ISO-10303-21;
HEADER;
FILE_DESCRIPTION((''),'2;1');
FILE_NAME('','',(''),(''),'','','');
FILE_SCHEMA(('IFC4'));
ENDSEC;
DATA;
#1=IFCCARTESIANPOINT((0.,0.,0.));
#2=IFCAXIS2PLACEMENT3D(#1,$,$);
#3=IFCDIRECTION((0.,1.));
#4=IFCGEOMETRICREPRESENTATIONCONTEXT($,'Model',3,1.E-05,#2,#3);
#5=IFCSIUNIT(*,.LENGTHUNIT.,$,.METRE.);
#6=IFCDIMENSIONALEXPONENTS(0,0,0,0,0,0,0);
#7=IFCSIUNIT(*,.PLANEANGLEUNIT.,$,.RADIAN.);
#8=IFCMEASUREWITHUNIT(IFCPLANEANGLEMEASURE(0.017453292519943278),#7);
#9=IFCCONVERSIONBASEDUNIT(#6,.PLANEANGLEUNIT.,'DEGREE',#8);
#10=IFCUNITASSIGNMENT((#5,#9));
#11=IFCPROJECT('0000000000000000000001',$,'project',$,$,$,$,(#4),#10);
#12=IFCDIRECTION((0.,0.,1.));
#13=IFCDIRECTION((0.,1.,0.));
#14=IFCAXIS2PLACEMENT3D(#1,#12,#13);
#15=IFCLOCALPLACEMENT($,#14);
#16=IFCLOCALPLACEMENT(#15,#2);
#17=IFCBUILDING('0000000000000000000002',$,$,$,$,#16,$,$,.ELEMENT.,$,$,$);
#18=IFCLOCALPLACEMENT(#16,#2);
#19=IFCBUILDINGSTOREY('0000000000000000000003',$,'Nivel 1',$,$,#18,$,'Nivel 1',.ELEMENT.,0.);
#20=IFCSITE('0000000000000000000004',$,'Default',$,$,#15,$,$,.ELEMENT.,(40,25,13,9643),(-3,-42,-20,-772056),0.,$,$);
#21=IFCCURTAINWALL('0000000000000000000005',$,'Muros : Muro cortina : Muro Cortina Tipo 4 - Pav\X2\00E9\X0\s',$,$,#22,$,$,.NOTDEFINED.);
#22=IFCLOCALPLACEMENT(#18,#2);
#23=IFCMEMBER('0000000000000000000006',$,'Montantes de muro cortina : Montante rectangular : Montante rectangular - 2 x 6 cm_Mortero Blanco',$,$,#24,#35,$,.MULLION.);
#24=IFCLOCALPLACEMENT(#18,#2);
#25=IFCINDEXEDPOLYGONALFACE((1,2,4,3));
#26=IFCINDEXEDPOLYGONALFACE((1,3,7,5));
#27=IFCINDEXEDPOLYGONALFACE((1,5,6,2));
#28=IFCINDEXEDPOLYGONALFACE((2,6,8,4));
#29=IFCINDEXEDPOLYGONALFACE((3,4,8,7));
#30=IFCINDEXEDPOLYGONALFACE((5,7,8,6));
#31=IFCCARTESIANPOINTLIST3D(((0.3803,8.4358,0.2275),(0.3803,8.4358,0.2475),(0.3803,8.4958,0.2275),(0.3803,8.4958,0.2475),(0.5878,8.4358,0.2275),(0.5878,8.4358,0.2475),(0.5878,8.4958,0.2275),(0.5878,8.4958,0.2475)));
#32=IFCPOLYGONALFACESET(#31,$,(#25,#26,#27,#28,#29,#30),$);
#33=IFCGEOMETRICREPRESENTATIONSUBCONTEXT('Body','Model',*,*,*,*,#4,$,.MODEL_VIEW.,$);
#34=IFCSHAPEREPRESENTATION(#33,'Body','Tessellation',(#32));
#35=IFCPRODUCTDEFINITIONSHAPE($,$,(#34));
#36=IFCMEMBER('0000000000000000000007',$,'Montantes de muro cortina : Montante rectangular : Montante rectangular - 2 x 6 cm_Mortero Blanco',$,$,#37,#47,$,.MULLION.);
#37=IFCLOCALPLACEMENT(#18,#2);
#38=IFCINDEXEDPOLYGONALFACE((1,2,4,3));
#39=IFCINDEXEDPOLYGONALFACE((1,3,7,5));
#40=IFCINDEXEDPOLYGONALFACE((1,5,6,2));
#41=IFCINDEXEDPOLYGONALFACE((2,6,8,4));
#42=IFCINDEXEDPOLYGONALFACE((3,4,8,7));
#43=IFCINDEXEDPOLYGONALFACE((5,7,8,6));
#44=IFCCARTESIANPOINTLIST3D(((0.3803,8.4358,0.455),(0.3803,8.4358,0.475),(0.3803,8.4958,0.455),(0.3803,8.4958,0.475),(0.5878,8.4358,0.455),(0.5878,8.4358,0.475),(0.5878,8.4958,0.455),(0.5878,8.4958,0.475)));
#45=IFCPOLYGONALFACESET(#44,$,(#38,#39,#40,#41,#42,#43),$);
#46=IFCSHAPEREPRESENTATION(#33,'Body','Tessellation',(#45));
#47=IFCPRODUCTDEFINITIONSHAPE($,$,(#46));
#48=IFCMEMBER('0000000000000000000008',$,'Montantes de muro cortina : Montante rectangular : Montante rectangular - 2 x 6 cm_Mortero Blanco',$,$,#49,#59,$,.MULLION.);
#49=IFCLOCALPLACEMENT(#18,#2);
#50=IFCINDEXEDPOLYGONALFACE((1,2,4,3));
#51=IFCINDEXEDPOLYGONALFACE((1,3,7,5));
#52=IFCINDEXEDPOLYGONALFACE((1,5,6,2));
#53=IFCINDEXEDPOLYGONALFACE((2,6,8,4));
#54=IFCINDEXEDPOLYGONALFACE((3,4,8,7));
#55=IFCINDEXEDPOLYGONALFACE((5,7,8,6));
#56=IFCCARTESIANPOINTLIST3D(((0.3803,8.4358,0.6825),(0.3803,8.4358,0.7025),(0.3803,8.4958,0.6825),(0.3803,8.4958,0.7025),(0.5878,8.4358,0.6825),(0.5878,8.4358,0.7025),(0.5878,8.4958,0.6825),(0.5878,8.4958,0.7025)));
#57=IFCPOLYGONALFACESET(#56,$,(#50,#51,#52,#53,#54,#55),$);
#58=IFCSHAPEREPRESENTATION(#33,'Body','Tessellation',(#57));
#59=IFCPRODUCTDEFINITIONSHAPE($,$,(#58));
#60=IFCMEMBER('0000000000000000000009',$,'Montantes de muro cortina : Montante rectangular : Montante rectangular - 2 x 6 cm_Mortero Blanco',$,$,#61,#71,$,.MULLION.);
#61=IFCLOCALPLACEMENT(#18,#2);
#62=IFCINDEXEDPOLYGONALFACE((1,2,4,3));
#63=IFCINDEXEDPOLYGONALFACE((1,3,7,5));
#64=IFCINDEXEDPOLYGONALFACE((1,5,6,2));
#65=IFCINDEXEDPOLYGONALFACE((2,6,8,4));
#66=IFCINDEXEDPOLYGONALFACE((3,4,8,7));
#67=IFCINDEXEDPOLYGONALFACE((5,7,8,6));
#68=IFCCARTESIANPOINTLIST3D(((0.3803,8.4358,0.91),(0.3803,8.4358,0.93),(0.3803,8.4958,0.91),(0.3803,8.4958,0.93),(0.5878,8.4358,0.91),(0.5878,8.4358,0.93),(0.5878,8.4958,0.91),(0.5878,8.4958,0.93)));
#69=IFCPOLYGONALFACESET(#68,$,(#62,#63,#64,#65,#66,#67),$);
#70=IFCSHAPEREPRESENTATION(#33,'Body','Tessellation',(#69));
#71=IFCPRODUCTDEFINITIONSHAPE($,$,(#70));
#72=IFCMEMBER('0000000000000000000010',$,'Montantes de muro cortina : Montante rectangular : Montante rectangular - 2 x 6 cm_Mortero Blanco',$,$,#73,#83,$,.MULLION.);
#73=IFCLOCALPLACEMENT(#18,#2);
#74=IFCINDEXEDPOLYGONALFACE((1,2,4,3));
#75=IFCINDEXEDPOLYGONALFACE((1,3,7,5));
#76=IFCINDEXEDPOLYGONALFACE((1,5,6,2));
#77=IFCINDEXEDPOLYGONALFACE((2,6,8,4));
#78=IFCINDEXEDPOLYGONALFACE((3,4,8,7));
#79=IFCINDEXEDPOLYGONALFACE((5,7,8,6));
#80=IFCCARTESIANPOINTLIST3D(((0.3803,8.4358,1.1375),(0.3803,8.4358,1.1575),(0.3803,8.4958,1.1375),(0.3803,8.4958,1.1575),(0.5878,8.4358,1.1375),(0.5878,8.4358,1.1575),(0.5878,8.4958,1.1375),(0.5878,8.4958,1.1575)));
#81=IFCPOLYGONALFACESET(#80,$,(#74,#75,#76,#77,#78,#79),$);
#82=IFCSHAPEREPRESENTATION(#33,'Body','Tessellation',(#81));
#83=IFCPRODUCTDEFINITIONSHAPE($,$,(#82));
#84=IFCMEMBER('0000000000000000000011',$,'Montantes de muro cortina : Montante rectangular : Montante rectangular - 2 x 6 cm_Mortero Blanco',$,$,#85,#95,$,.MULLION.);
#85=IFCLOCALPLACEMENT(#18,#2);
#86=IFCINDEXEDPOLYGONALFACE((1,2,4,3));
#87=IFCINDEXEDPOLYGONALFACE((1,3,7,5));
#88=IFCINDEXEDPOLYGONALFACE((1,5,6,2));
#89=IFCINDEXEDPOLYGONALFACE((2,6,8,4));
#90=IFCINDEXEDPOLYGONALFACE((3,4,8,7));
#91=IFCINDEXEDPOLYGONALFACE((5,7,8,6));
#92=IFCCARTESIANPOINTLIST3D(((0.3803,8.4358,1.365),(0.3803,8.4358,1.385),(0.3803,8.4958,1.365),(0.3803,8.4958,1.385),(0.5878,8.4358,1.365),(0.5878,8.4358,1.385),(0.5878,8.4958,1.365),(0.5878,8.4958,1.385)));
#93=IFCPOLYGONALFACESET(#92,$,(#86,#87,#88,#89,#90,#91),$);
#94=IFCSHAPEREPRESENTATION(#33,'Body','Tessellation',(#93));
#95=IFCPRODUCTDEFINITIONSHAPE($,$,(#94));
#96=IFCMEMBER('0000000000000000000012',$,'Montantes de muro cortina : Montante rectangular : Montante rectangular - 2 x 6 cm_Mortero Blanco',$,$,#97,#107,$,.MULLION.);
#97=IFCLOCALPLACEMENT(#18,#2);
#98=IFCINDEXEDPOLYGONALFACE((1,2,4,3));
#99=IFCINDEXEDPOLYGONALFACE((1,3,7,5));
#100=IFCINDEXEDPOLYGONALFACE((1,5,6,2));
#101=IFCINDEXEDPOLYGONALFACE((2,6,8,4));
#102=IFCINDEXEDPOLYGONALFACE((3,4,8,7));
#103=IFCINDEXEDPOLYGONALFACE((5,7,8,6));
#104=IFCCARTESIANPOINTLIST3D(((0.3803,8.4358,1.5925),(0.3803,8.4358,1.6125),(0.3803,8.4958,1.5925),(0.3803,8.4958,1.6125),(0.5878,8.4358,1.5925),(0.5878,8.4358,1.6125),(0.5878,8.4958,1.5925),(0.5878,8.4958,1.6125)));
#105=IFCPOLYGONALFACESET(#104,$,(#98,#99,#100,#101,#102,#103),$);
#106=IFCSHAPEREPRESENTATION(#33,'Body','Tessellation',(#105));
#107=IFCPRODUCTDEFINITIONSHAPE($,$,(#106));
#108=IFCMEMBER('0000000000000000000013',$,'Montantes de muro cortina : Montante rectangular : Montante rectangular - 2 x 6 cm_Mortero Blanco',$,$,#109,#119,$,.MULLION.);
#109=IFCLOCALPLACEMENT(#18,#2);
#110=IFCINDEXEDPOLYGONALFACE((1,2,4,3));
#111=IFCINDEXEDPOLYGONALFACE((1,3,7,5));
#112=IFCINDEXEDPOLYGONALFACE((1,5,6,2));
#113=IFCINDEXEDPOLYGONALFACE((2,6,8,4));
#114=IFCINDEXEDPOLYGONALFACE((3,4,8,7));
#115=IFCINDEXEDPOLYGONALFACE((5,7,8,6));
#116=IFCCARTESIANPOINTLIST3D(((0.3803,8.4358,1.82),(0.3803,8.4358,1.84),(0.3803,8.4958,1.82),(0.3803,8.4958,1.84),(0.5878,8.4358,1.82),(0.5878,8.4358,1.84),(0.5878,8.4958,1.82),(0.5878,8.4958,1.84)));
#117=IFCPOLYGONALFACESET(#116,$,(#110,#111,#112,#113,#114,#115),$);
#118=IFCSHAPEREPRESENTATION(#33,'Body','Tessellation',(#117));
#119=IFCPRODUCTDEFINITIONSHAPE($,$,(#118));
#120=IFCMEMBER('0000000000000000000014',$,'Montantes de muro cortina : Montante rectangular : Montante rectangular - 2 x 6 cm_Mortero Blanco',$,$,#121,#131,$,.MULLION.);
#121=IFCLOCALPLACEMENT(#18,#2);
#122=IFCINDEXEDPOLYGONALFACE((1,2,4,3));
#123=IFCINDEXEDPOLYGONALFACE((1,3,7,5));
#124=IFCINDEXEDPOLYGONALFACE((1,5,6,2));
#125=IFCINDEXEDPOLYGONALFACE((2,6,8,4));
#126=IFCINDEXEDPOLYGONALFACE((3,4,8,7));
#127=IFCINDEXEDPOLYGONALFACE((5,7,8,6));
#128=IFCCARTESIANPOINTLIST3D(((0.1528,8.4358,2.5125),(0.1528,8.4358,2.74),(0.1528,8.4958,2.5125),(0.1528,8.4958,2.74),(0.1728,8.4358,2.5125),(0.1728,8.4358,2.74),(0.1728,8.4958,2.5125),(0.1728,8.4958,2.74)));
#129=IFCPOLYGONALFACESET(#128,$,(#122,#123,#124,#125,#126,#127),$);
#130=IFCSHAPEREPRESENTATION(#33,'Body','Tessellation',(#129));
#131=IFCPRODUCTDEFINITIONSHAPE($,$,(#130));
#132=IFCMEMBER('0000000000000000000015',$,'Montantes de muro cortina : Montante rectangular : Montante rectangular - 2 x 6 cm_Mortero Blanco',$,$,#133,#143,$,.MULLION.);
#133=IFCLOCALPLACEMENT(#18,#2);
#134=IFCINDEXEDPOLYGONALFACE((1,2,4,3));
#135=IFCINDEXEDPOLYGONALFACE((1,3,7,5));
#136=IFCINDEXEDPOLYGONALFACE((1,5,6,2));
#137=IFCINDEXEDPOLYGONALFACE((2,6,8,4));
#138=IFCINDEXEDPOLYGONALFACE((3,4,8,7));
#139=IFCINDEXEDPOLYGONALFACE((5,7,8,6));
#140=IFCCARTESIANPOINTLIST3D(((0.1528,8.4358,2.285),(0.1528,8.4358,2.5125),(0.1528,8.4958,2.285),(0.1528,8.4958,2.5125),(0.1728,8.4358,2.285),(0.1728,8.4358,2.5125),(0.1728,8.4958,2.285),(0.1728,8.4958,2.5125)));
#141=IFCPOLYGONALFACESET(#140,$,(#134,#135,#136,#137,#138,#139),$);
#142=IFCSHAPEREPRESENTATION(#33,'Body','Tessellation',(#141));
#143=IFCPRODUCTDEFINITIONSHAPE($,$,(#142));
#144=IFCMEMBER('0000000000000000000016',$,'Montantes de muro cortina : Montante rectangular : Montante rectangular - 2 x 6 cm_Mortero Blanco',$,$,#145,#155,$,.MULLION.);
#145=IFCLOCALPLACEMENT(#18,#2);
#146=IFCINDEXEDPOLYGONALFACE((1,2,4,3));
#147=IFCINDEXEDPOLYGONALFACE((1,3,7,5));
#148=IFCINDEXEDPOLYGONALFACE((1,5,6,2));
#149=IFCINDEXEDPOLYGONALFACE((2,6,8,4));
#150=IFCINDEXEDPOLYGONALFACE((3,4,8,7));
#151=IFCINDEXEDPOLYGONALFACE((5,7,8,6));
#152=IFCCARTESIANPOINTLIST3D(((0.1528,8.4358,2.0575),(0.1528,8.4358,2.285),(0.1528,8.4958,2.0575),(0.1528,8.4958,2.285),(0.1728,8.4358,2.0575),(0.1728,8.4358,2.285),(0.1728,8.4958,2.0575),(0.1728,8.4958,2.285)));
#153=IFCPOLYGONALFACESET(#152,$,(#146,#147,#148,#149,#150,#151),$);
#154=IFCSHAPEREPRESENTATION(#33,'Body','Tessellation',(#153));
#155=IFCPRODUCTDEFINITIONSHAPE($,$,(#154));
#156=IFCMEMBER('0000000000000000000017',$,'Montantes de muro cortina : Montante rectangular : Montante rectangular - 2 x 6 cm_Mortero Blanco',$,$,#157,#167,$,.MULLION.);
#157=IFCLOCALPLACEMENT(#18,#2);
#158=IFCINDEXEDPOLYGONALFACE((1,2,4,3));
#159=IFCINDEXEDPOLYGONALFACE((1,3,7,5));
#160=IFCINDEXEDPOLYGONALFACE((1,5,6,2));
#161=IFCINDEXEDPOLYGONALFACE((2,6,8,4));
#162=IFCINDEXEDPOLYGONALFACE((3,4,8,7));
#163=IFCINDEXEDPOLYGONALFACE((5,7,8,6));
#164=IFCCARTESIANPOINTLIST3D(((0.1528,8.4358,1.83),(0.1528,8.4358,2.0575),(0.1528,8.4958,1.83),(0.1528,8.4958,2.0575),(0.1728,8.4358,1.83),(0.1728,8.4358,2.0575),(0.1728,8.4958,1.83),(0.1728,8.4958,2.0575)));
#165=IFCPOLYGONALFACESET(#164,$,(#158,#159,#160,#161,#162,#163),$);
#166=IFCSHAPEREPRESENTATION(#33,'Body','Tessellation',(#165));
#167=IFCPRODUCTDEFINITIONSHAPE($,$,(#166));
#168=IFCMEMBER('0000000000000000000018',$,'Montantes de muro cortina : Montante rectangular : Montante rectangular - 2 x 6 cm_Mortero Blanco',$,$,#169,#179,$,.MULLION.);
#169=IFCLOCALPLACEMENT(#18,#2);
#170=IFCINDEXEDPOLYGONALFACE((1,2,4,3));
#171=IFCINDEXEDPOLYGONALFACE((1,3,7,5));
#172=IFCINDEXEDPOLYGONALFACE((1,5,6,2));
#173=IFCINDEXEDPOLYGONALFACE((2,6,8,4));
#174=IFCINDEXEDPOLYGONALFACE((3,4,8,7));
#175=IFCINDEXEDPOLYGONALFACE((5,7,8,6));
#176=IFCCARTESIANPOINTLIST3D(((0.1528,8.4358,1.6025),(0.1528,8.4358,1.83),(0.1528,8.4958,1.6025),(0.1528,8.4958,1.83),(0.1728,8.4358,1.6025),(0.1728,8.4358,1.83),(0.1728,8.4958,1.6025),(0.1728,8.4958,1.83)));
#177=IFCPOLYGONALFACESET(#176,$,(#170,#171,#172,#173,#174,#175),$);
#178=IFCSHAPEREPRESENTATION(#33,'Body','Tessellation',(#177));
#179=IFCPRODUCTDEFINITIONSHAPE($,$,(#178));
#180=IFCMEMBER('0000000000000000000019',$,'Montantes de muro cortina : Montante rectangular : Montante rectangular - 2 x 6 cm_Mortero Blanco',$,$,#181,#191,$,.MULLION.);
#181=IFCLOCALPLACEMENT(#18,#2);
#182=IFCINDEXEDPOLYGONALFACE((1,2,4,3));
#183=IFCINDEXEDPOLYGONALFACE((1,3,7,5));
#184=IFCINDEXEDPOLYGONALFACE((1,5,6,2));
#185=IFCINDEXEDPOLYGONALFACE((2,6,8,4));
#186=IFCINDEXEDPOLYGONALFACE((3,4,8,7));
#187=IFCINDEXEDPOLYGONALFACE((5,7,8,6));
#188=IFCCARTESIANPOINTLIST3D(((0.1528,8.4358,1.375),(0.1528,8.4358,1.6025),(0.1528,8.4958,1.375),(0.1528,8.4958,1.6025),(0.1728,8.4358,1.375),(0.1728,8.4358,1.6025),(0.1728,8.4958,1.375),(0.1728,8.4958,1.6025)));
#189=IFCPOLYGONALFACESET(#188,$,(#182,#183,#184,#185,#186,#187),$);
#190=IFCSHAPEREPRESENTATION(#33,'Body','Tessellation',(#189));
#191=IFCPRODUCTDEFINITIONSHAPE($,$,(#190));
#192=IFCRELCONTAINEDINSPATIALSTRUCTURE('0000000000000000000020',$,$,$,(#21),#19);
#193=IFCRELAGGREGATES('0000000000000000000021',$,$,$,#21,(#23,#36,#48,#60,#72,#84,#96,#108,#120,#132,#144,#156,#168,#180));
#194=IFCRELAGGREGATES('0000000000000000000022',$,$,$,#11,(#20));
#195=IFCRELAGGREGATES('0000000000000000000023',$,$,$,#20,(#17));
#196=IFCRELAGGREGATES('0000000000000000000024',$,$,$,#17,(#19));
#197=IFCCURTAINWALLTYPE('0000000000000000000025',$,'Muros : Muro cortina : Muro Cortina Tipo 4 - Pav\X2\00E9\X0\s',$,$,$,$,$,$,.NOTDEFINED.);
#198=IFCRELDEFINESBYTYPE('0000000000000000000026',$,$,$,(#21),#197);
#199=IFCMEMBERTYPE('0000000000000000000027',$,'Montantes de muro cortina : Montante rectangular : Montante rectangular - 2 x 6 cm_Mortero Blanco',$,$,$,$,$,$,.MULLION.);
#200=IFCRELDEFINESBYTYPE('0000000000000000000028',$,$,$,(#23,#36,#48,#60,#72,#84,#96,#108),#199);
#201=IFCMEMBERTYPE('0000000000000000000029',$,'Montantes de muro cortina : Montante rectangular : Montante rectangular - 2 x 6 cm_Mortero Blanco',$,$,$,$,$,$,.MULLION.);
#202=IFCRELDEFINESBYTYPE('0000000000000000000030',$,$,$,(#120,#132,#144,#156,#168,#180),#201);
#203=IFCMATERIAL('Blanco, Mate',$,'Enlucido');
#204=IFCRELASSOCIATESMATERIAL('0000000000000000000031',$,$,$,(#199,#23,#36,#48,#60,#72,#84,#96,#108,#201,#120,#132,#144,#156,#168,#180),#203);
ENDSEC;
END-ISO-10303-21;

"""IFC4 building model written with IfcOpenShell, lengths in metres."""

from ifc_helpers import new_model, entity, si_unit, converted_unit, direction, frame, origin, place, context, subcontext, project, spatial, indexed_curve, outline, extrude, source, transform, mapped, material, type_object, type_shapes, element, aggregate, save


model = new_model("IFC4")

# Units and contexts
model_context = context("Model", 3, precision=1e-05, world=origin(), true_north=direction((0.0, 1.0)))
body_context = subcontext(model_context, "Body", "Model", "MODEL_VIEW")
ifc_project = project(units=[si_unit("LENGTHUNIT", "METRE"), converted_unit("PLANEANGLEUNIT", "DEGREE", entity("IfcPlaneAngleMeasure", 0.017453292519943278), si_unit("PLANEANGLEUNIT", "RADIAN"), dimensions=[0, 0, 0, 0, 0, 0, 0])], contexts=[model_context])

# Site, building, storey
site_placement = place(None, frame((0.0, 0.0, 0.0), z_axis=(0.0, 0.0, 1.0), x_axis=(0.0, 1.0, 0.0)))
site = spatial("IfcSite", under=ifc_project, at=site_placement, Name="Default", CompositionType="ELEMENT", RefLatitude=(40, 25, 13, 9643), RefLongitude=(-3, -42, -20, -772056), RefElevation=0.0)
building_placement = place(site_placement, origin())
building = spatial("IfcBuilding", under=site, at=building_placement, CompositionType="ELEMENT")
storey_placement = place(building_placement, origin())
storey = spatial("IfcBuildingStorey", under=building, at=storey_placement, Name="Nivel 1", LongName="Nivel 1", CompositionType="ELEMENT", Elevation=0.0)

# Curtain wall, members
curtain_wall_type = type_object("IfcCurtainWallType", Name="Muros : Muro cortina : Muro Cortina Tipo 4 - Pavés", PredefinedType="NOTDEFINED")
curtain_wall_placement = place(storey_placement, origin())
curtain_wall = element("IfcCurtainWall", 1, at=curtain_wall_placement, inside=storey, type_object=curtain_wall_type, Name="Muros : Muro cortina : Muro Cortina Tipo 4 - Pavés", PredefinedType="NOTDEFINED")
ifc_material_1 = material(Name="Blanco, Mate", Category="Enlucido")
member_type_1 = type_object("IfcMemberType", Name="Montantes de muro cortina : Montante rectangular : Montante rectangular - 2 x 6 cm_Mortero Blanco", PredefinedType="MULLION", material=ifc_material_1)
shared_shape_1 = source(origin(), body_context, "Body", "SweptSolid", [
    extrude(outline(indexed_curve([(-0.01, -0.03), (0.01, -0.03), (0.01, 0.03), (-0.01, 0.03), (-0.01, -0.03)], self_intersect=False)), frame((0.0, 0.0, -0.2075), z_axis=(0.0, 0.0, 1.0), x_axis=(-1.0, 0.0, 0.0)), (0.0, 0.0, 1.0), 0.2075),
])
type_shapes(member_type_1, [shared_shape_1])
member_1_placement = place(curtain_wall_placement, frame((0.3803, 8.4658, 0.2375), z_axis=(-1.0, 0.0, 0.0), x_axis=(0.0, 0.0, 1.0)))
member_1 = element("IfcMember", 2, at=member_1_placement, type_object=member_type_1, material=ifc_material_1, Name="Montantes de muro cortina : Montante rectangular : Montante rectangular - 2 x 6 cm_Mortero Blanco", PredefinedType="MULLION", context=body_context, shape_type="MappedRepresentation", body=[
    mapped(shared_shape_1, transform((0.0, 0.0, 0.0), scale=1.0)),
])
member_2_placement = place(curtain_wall_placement, frame((0.3803, 8.4658, 0.465), z_axis=(-1.0, 0.0, 0.0), x_axis=(0.0, 0.0, 1.0)))
member_2 = element("IfcMember", 3, at=member_2_placement, type_object=member_type_1, material=ifc_material_1, Name="Montantes de muro cortina : Montante rectangular : Montante rectangular - 2 x 6 cm_Mortero Blanco", PredefinedType="MULLION", context=body_context, shape_type="MappedRepresentation", body=[
    mapped(shared_shape_1, transform((0.0, 0.0, 0.0), scale=1.0)),
])
member_3_placement = place(curtain_wall_placement, frame((0.3803, 8.4658, 0.6925), z_axis=(-1.0, 0.0, 0.0), x_axis=(0.0, 0.0, 1.0)))
member_3 = element("IfcMember", 4, at=member_3_placement, type_object=member_type_1, material=ifc_material_1, Name="Montantes de muro cortina : Montante rectangular : Montante rectangular - 2 x 6 cm_Mortero Blanco", PredefinedType="MULLION", context=body_context, shape_type="MappedRepresentation", body=[
    mapped(shared_shape_1, transform((0.0, 0.0, 0.0), scale=1.0)),
])
member_4_placement = place(curtain_wall_placement, frame((0.3803, 8.4658, 0.92), z_axis=(-1.0, 0.0, 0.0), x_axis=(0.0, 0.0, 1.0)))
member_4 = element("IfcMember", 5, at=member_4_placement, type_object=member_type_1, material=ifc_material_1, Name="Montantes de muro cortina : Montante rectangular : Montante rectangular - 2 x 6 cm_Mortero Blanco", PredefinedType="MULLION", context=body_context, shape_type="MappedRepresentation", body=[
    mapped(shared_shape_1, transform((0.0, 0.0, 0.0), scale=1.0)),
])
member_5_placement = place(curtain_wall_placement, frame((0.3803, 8.4658, 1.1475), z_axis=(-1.0, 0.0, 0.0), x_axis=(0.0, 0.0, 1.0)))
member_5 = element("IfcMember", 6, at=member_5_placement, type_object=member_type_1, material=ifc_material_1, Name="Montantes de muro cortina : Montante rectangular : Montante rectangular - 2 x 6 cm_Mortero Blanco", PredefinedType="MULLION", context=body_context, shape_type="MappedRepresentation", body=[
    mapped(shared_shape_1, transform((0.0, 0.0, 0.0), scale=1.0)),
])
member_6_placement = place(curtain_wall_placement, frame((0.3803, 8.4658, 1.375), z_axis=(-1.0, 0.0, 0.0), x_axis=(0.0, 0.0, 1.0)))
member_6 = element("IfcMember", 7, at=member_6_placement, type_object=member_type_1, material=ifc_material_1, Name="Montantes de muro cortina : Montante rectangular : Montante rectangular - 2 x 6 cm_Mortero Blanco", PredefinedType="MULLION", context=body_context, shape_type="MappedRepresentation", body=[
    mapped(shared_shape_1, transform((0.0, 0.0, 0.0), scale=1.0)),
])
member_7_placement = place(curtain_wall_placement, frame((0.3803, 8.4658, 1.6025), z_axis=(-1.0, 0.0, 0.0), x_axis=(0.0, 0.0, 1.0)))
member_7 = element("IfcMember", 8, at=member_7_placement, type_object=member_type_1, material=ifc_material_1, Name="Montantes de muro cortina : Montante rectangular : Montante rectangular - 2 x 6 cm_Mortero Blanco", PredefinedType="MULLION", context=body_context, shape_type="MappedRepresentation", body=[
    mapped(shared_shape_1, transform((0.0, 0.0, 0.0), scale=1.0)),
])
member_8_placement = place(curtain_wall_placement, frame((0.3803, 8.4658, 1.83), z_axis=(-1.0, 0.0, 0.0), x_axis=(0.0, 0.0, 1.0)))
member_8 = element("IfcMember", 9, at=member_8_placement, type_object=member_type_1, material=ifc_material_1, Name="Montantes de muro cortina : Montante rectangular : Montante rectangular - 2 x 6 cm_Mortero Blanco", PredefinedType="MULLION", context=body_context, shape_type="MappedRepresentation", body=[
    mapped(shared_shape_1, transform((0.0, 0.0, 0.0), scale=1.0)),
])
member_type_2 = type_object("IfcMemberType", Name="Montantes de muro cortina : Montante rectangular : Montante rectangular - 2 x 6 cm_Mortero Blanco", PredefinedType="MULLION", material=ifc_material_1)
shared_shape_2 = source(origin(), body_context, "Body", "SweptSolid", [
    extrude(outline(indexed_curve([(-0.01, -0.03), (0.01, -0.03), (0.01, 0.03), (-0.01, 0.03), (-0.01, -0.03)], self_intersect=False)), frame((-0.01, 0.0, -0.2275), z_axis=(0.0, 0.0, 1.0), x_axis=(-1.0, 0.0, 0.0)), (0.0, 0.0, 1.0), 0.2275),
])
type_shapes(member_type_2, [shared_shape_2])
member_9_placement = place(curtain_wall_placement, frame((0.1528, 8.4658, 2.5125), z_axis=(0.0, 0.0, -1.0), x_axis=(-1.0, 0.0, 0.0)))
member_9 = element("IfcMember", 10, at=member_9_placement, type_object=member_type_2, material=ifc_material_1, Name="Montantes de muro cortina : Montante rectangular : Montante rectangular - 2 x 6 cm_Mortero Blanco", PredefinedType="MULLION", context=body_context, shape_type="MappedRepresentation", body=[
    mapped(shared_shape_2, transform((0.0, 0.0, 0.0), scale=1.0)),
])
member_10_placement = place(curtain_wall_placement, frame((0.1528, 8.4658, 2.285), z_axis=(0.0, 0.0, -1.0), x_axis=(-1.0, 0.0, 0.0)))
member_10 = element("IfcMember", 11, at=member_10_placement, type_object=member_type_2, material=ifc_material_1, Name="Montantes de muro cortina : Montante rectangular : Montante rectangular - 2 x 6 cm_Mortero Blanco", PredefinedType="MULLION", context=body_context, shape_type="MappedRepresentation", body=[
    mapped(shared_shape_2, transform((0.0, 0.0, 0.0), scale=1.0)),
])
member_11_placement = place(curtain_wall_placement, frame((0.1528, 8.4658, 2.0575), z_axis=(0.0, 0.0, -1.0), x_axis=(-1.0, 0.0, 0.0)))
member_11 = element("IfcMember", 12, at=member_11_placement, type_object=member_type_2, material=ifc_material_1, Name="Montantes de muro cortina : Montante rectangular : Montante rectangular - 2 x 6 cm_Mortero Blanco", PredefinedType="MULLION", context=body_context, shape_type="MappedRepresentation", body=[
    mapped(shared_shape_2, transform((0.0, 0.0, 0.0), scale=1.0)),
])
member_12_placement = place(curtain_wall_placement, frame((0.1528, 8.4658, 1.83), z_axis=(0.0, 0.0, -1.0), x_axis=(-1.0, 0.0, 0.0)))
member_12 = element("IfcMember", 13, at=member_12_placement, type_object=member_type_2, material=ifc_material_1, Name="Montantes de muro cortina : Montante rectangular : Montante rectangular - 2 x 6 cm_Mortero Blanco", PredefinedType="MULLION", context=body_context, shape_type="MappedRepresentation", body=[
    mapped(shared_shape_2, transform((0.0, 0.0, 0.0), scale=1.0)),
])
member_13_placement = place(curtain_wall_placement, frame((0.1528, 8.4658, 1.6025), z_axis=(0.0, 0.0, -1.0), x_axis=(-1.0, 0.0, 0.0)))
member_13 = element("IfcMember", 14, at=member_13_placement, type_object=member_type_2, material=ifc_material_1, Name="Montantes de muro cortina : Montante rectangular : Montante rectangular - 2 x 6 cm_Mortero Blanco", PredefinedType="MULLION", context=body_context, shape_type="MappedRepresentation", body=[
    mapped(shared_shape_2, transform((0.0, 0.0, 0.0), scale=1.0)),
])
member_14_placement = place(curtain_wall_placement, frame((0.1528, 8.4658, 1.375), z_axis=(0.0, 0.0, -1.0), x_axis=(-1.0, 0.0, 0.0)))
member_14 = element("IfcMember", 15, at=member_14_placement, type_object=member_type_2, material=ifc_material_1, Name="Montantes de muro cortina : Montante rectangular : Montante rectangular - 2 x 6 cm_Mortero Blanco", PredefinedType="MULLION", context=body_context, shape_type="MappedRepresentation", body=[
    mapped(shared_shape_2, transform((0.0, 0.0, 0.0), scale=1.0)),
])
aggregate(curtain_wall, [member_1, member_2, member_3, member_4, member_5, member_6, member_7, member_8, member_9, member_10, member_11, member_12, member_13, member_14])

save(model, "model.ifc")
